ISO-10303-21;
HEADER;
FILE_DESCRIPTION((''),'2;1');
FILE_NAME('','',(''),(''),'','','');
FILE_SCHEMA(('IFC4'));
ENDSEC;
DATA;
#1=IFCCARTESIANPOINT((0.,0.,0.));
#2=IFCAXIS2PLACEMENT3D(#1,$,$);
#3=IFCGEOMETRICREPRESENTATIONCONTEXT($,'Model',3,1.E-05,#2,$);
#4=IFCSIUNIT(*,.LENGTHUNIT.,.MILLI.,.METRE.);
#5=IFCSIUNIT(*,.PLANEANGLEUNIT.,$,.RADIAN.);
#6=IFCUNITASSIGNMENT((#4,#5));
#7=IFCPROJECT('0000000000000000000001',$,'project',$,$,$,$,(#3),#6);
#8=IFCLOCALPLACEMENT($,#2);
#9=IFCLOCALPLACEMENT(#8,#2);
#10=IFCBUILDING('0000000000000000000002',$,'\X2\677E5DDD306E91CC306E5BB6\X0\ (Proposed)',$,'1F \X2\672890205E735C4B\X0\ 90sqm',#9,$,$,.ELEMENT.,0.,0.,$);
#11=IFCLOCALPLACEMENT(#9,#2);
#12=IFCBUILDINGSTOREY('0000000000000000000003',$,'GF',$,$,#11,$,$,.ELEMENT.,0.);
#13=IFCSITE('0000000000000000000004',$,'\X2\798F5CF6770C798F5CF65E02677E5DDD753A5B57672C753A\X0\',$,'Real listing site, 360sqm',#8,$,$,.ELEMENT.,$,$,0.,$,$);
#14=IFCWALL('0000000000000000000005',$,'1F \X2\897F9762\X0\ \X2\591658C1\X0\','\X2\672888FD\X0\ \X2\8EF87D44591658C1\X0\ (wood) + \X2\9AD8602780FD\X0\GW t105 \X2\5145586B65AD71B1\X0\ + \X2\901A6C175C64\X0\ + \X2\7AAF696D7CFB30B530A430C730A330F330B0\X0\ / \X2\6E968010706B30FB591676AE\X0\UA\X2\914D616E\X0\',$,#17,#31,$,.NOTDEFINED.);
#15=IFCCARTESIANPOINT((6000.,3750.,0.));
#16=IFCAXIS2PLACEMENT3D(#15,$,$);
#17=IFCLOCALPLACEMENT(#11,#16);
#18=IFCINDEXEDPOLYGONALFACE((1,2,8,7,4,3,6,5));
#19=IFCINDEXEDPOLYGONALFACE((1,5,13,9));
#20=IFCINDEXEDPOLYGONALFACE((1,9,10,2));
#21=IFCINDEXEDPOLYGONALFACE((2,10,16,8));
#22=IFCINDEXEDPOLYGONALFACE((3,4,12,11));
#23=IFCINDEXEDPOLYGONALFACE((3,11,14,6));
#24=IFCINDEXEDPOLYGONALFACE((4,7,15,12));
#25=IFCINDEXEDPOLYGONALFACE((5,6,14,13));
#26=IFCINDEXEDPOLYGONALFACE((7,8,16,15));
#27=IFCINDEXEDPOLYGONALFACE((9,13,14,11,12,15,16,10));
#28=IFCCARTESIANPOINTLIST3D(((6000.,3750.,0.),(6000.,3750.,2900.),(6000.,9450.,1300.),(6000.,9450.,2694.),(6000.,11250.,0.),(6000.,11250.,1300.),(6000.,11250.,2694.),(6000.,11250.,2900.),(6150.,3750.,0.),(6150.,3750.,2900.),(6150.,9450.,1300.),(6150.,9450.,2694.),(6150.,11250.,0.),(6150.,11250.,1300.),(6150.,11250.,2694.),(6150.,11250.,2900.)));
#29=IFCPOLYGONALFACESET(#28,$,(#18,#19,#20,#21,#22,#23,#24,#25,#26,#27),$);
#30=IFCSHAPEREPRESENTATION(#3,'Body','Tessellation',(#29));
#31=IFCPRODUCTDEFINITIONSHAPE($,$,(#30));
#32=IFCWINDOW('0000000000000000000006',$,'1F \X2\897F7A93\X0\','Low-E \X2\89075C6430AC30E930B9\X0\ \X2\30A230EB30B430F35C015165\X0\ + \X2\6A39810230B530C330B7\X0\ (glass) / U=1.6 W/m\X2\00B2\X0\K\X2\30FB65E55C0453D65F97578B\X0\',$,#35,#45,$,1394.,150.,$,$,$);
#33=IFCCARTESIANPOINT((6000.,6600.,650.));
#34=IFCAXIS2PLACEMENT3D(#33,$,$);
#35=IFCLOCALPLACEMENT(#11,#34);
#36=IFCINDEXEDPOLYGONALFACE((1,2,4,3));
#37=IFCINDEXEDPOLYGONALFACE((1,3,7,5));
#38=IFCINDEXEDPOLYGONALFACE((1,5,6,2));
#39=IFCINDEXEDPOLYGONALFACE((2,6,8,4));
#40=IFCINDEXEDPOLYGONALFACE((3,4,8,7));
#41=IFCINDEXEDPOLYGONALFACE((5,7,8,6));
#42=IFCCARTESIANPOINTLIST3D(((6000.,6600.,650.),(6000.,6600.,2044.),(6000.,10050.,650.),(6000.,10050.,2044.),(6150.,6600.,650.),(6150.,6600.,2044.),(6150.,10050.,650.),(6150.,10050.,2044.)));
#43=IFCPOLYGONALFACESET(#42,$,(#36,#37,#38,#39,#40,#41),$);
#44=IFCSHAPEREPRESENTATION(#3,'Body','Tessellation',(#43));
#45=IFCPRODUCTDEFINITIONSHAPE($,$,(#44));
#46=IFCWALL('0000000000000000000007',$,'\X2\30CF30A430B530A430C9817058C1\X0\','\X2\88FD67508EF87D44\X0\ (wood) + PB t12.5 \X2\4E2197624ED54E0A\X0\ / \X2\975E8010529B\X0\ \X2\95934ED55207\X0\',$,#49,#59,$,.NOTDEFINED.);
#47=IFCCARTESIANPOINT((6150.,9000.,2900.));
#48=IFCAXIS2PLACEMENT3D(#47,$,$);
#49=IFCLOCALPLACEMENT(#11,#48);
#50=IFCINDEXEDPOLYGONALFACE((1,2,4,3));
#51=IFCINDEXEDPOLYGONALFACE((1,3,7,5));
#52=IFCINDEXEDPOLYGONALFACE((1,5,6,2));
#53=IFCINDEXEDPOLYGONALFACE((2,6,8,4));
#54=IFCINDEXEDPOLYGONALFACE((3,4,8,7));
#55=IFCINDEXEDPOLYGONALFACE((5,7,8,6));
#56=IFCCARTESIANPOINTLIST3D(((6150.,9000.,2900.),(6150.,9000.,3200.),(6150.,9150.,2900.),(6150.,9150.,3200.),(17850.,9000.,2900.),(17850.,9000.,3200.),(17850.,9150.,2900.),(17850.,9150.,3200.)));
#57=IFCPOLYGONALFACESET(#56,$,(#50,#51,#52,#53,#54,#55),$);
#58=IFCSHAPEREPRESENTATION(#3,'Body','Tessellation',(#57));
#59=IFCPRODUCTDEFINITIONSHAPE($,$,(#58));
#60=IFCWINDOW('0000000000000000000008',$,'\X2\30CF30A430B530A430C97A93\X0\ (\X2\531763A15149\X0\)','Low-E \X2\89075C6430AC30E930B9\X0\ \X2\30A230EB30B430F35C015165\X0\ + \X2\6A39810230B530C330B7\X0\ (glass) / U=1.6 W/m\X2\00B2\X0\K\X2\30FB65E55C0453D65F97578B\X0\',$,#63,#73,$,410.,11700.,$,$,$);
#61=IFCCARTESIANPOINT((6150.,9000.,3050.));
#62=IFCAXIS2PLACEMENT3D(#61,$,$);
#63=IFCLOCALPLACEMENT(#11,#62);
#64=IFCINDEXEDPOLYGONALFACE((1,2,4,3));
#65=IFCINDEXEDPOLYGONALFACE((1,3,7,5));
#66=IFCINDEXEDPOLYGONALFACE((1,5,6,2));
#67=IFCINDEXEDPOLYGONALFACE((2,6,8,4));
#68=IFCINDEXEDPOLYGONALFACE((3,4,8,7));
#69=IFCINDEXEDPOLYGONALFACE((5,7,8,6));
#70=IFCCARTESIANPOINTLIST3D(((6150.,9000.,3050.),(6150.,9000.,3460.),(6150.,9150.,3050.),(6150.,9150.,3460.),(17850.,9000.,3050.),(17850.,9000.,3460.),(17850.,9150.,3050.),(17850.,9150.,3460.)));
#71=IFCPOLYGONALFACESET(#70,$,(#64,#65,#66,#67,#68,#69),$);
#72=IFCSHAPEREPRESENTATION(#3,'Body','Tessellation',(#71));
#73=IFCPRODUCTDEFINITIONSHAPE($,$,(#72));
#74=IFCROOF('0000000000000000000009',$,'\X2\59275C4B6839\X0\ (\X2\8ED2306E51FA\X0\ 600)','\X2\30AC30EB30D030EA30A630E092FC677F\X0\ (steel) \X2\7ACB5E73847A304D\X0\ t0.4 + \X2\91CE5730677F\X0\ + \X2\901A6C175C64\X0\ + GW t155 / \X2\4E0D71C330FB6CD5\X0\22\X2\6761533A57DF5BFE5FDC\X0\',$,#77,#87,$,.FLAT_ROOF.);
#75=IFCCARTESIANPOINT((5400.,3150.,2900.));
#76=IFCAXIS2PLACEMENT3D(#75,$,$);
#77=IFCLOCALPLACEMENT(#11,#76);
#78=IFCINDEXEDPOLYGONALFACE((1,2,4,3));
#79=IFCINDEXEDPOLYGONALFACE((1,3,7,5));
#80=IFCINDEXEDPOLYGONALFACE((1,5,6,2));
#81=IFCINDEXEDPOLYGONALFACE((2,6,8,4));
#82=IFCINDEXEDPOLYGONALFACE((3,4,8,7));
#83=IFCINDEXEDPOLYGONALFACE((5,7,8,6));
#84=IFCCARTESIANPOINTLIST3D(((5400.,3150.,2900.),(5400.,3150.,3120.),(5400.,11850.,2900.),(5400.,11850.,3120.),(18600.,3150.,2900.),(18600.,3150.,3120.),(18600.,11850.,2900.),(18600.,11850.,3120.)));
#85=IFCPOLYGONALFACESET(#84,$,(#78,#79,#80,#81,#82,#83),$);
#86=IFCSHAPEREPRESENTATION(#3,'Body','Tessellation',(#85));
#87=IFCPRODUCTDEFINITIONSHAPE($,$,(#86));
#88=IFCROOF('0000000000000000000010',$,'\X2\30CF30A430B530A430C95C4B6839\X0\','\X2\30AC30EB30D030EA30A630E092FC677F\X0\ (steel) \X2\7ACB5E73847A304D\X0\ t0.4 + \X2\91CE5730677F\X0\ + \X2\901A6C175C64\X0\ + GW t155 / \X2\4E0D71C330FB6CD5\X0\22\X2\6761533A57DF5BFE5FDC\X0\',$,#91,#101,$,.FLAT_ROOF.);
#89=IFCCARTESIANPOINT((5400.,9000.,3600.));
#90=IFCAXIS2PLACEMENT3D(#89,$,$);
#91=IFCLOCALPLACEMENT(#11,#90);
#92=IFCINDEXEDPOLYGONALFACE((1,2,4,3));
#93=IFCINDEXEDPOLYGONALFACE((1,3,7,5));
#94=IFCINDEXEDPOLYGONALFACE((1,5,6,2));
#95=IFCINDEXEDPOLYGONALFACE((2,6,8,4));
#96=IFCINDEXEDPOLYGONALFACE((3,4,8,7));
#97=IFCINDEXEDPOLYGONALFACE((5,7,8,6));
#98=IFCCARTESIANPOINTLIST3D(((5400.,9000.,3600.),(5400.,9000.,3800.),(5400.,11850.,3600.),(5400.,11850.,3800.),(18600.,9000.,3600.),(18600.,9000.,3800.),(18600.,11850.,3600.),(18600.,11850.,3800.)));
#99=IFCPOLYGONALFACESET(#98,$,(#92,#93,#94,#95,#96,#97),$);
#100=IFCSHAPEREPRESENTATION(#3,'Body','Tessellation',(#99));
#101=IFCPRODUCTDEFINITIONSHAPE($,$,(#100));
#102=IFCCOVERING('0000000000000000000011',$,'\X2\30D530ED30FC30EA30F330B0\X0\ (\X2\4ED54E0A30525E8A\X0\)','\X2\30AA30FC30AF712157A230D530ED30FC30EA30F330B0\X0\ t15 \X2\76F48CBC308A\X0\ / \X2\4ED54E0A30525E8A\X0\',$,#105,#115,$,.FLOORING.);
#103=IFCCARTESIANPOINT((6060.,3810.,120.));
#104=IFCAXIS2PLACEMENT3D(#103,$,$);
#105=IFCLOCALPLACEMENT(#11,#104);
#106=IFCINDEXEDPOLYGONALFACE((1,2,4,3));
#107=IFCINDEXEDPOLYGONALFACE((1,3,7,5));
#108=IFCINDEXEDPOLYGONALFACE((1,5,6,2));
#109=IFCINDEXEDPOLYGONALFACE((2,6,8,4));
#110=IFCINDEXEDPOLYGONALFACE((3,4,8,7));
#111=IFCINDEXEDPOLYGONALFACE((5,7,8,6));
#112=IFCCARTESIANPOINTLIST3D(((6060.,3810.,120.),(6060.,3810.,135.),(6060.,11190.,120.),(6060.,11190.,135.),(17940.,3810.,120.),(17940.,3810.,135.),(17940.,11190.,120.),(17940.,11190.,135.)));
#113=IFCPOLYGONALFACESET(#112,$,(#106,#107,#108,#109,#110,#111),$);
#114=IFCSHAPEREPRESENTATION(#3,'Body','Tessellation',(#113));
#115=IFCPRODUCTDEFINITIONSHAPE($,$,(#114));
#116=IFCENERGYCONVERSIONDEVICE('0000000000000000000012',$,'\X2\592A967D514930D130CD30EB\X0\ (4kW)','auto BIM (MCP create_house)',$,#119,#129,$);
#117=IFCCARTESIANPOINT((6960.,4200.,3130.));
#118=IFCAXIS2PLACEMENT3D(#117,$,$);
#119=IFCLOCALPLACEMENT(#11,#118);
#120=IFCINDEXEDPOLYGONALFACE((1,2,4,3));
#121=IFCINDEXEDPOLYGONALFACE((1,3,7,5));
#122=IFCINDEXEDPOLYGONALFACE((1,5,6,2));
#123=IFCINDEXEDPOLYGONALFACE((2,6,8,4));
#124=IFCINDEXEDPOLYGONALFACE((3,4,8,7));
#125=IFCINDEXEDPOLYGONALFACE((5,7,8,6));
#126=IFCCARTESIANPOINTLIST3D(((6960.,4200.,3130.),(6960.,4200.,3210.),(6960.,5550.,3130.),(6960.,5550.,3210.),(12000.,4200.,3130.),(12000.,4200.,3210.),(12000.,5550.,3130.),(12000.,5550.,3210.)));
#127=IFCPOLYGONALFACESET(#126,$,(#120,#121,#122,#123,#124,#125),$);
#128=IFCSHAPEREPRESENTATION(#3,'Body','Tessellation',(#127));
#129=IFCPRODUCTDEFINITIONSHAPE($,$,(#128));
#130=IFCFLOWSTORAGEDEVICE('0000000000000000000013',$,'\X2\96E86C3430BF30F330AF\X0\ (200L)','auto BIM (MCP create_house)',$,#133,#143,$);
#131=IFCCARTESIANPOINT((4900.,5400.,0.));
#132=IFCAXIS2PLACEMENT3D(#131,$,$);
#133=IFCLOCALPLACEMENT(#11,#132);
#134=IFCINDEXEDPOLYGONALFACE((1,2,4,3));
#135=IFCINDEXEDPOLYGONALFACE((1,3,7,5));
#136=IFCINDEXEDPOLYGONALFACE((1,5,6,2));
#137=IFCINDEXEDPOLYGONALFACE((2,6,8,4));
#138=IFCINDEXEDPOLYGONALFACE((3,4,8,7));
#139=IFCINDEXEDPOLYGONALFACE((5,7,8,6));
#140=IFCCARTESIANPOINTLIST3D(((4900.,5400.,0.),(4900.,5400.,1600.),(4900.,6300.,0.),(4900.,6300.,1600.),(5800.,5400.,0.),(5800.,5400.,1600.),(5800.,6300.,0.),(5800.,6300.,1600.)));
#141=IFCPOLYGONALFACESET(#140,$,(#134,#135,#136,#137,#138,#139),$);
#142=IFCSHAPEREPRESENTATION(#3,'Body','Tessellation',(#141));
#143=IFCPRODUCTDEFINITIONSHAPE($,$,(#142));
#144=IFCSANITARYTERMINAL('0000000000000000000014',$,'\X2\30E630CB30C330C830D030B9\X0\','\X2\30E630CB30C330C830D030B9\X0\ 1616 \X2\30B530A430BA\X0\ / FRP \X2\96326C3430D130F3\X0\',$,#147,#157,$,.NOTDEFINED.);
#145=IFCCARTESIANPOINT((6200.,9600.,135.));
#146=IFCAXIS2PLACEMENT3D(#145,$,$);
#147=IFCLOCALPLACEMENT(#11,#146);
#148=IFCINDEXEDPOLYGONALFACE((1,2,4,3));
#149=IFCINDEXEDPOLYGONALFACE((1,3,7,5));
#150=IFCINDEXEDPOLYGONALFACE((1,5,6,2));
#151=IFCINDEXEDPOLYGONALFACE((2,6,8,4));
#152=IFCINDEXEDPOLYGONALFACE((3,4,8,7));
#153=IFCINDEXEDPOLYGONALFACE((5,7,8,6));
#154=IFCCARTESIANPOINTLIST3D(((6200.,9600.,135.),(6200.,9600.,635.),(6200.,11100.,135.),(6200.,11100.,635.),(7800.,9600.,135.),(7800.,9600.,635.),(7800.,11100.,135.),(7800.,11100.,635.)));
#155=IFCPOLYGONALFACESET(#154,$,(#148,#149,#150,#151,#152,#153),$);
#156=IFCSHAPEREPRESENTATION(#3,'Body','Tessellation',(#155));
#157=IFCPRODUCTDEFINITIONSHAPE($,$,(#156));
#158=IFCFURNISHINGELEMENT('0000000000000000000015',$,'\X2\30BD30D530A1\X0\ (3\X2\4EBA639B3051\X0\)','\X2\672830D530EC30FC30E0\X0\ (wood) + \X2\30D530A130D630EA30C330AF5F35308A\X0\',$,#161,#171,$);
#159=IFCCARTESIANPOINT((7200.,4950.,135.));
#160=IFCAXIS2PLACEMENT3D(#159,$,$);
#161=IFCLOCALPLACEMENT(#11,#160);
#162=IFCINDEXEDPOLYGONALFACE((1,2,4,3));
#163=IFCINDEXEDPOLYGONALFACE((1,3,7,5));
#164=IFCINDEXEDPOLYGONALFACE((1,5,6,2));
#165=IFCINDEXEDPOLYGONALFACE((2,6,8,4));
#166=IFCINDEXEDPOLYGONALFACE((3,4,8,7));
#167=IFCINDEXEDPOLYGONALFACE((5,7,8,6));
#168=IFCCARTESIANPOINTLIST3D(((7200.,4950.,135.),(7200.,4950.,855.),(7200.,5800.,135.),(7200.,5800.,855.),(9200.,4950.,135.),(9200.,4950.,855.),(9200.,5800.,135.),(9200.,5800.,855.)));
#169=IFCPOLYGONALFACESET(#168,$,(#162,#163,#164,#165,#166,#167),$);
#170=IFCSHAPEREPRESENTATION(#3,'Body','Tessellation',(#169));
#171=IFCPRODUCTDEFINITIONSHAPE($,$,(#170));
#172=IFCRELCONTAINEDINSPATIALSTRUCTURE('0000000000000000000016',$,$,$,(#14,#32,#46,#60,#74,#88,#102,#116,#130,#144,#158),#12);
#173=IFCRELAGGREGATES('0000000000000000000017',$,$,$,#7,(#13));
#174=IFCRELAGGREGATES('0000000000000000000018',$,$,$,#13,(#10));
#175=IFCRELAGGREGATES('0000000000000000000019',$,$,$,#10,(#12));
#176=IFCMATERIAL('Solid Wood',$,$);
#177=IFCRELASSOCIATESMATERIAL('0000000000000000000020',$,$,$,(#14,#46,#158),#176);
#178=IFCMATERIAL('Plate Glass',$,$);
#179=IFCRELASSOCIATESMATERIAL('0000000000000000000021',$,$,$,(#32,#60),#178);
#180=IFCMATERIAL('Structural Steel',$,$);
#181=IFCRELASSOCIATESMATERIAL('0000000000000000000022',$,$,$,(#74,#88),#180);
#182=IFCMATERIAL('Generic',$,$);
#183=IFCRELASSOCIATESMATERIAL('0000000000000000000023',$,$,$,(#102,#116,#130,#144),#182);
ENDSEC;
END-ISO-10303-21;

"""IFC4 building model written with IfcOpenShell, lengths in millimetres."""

from ifc_helpers import new_model, si_unit, frame, frame_2d, origin, place, context, project, spatial, rectangle, extrude, material, element, fill, save


model = new_model("IFC4")

# Units and contexts
model_context = context("Model", 3, precision=1e-05, world=origin())
ifc_project = project(units=[si_unit("LENGTHUNIT", "METRE", prefix="MILLI"), si_unit("PLANEANGLEUNIT", "RADIAN")], contexts=[model_context])

# Site, building, storey
site_placement = place(None, origin())
site = spatial("IfcSite", under=ifc_project, at=site_placement, Name="福島県福島市松川町字本町", ObjectType="Real listing site, 360sqm", CompositionType="ELEMENT", RefElevation=0.0)
building_placement = place(site_placement, origin())
building = spatial("IfcBuilding", under=site, at=building_placement, Name="松川の里の家 (Proposed)", ObjectType="1F 木造平屋 90sqm", CompositionType="ELEMENT", ElevationOfRefHeight=0.0, ElevationOfTerrain=0.0)
storey_placement = place(building_placement, origin())
storey = spatial("IfcBuildingStorey", under=building, at=storey_placement, Name="GF", CompositionType="ELEMENT", Elevation=0.0)

# Shared definitions
ifc_material_1 = material(Name="Solid Wood")

# Shared definitions
ifc_material_2 = material(Name="Plate Glass")

# Wall, opening, window
wall_1_placement = place(storey_placement, frame((6000.0, 3750.0, 0.0)))
wall_1 = element("IfcWall", 1, at=wall_1_placement, inside=storey, material=ifc_material_1, Name="1F 西面 外壁", Description="木製 軸組外壁 (wood) + 高性能GW t105 充填断熱 + 通気層 + 窯業系サイディング / 準耐火・外皮UA配慮", PredefinedType="NOTDEFINED", context=model_context, shape_type="SweptSolid", body=[
    extrude(rectangle(XDim=150.0, YDim=7500.0, at=frame_2d((75.0, 3750.0))), frame((6000.0, 3750.0, 0.0)), (0.0, 0.0, 1.0), 2900.0),
])
opening_1_placement = place(storey_placement, frame((6000.0, 6600.0, 650.0)))
opening_1 = element("IfcOpeningElement", 2, at=opening_1_placement, cuts=wall_1, PredefinedType="NOTDEFINED", context=model_context, shape_type="SweptSolid", body=[
    extrude(rectangle(XDim=150.0, YDim=3450.0, at=frame_2d((75.0, 1725.0))), frame((6000.0, 6600.0, 650.0)), (0.0, 0.0, 1.0), 1394.0),
])
window_1_placement = place(storey_placement, frame((6000.0, 6600.0, 650.0)))
window_1 = element("IfcWindow", 3, at=window_1_placement, inside=storey, material=ifc_material_2, Name="1F 西窓", Description="Low-E 複層ガラス アルゴン封入 + 樹脂サッシ (glass) / U=1.6 W/m²K・日射取得型", OverallHeight=1394.0, OverallWidth=150.0, context=model_context, shape_type="SweptSolid", body=[
    extrude(rectangle(XDim=150.0, YDim=3450.0, at=frame_2d((75.0, 1725.0))), frame((6000.0, 6600.0, 650.0)), (0.0, 0.0, 1.0), 1394.0),
])
fill(opening_1, window_1)

# Wall, opening, window
wall_2_placement = place(storey_placement, frame((6150.0, 9000.0, 2900.0)))
wall_2 = element("IfcWall", 4, at=wall_2_placement, inside=storey, material=ifc_material_1, Name="ハイサイド腰壁", Description="製材軸組 (wood) + PB t12.5 両面仕上 / 非耐力 間仕切", PredefinedType="NOTDEFINED", context=model_context, shape_type="SweptSolid", body=[
    extrude(rectangle(XDim=11700.0, YDim=150.0, at=frame_2d((5850.0, 75.0))), frame((6150.0, 9000.0, 2900.0)), (0.0, 0.0, 1.0), 700.0),
])
opening_2_placement = place(storey_placement, frame((6150.0, 9000.0, 3050.0)))
opening_2 = element("IfcOpeningElement", 5, at=opening_2_placement, cuts=wall_2, PredefinedType="NOTDEFINED", context=model_context, shape_type="SweptSolid", body=[
    extrude(rectangle(XDim=11700.0, YDim=150.0, at=frame_2d((5850.0, 75.0))), frame((6150.0, 9000.0, 3050.0)), (0.0, 0.0, 1.0), 410.0),
])
window_2_placement = place(storey_placement, frame((6150.0, 9000.0, 3050.0)))
window_2 = element("IfcWindow", 6, at=window_2_placement, inside=storey, material=ifc_material_2, Name="ハイサイド窓 (北採光)", Description="Low-E 複層ガラス アルゴン封入 + 樹脂サッシ (glass) / U=1.6 W/m²K・日射取得型", OverallHeight=410.0, OverallWidth=11700.0, context=model_context, shape_type="SweptSolid", body=[
    extrude(rectangle(XDim=11700.0, YDim=150.0, at=frame_2d((5850.0, 75.0))), frame((6150.0, 9000.0, 3050.0)), (0.0, 0.0, 1.0), 410.0),
])
fill(opening_2, window_2)

# Roofs
ifc_material_3 = material(Name="Structural Steel")
roof_1_placement = place(storey_placement, frame((5400.0, 3150.0, 2900.0)))
element("IfcRoof", 7, at=roof_1_placement, inside=storey, material=ifc_material_3, Name="大屋根 (軒の出 600)", Description="ガルバリウム鋼板 (steel) 立平葺き t0.4 + 野地板 + 通気層 + GW t155 / 不燃・法22条区域対応", PredefinedType="FLAT_ROOF", context=model_context, shape_type="SweptSolid", body=[
    extrude(rectangle(XDim=13200.0, YDim=8700.0, at=frame_2d((6600.0, 4350.0))), frame((5400.0, 3150.0, 2900.0)), (0.0, 0.0, 1.0), 220.0),
])
roof_2_placement = place(storey_placement, frame((5400.0, 9000.0, 3600.0)))
element("IfcRoof", 8, at=roof_2_placement, inside=storey, material=ifc_material_3, Name="ハイサイド屋根", Description="ガルバリウム鋼板 (steel) 立平葺き t0.4 + 野地板 + 通気層 + GW t155 / 不燃・法22条区域対応", PredefinedType="FLAT_ROOF", context=model_context, shape_type="SweptSolid", body=[
    extrude(rectangle(XDim=13200.0, YDim=2850.0, at=frame_2d((6600.0, 1425.0))), frame((5400.0, 9000.0, 3600.0)), (0.0, 0.0, 1.0), 200.0),
])

# Covering
ifc_material_4 = material(Name="Generic")
covering_placement = place(storey_placement, frame((6060.0, 3810.0, 120.0)))
element("IfcCovering", 9, at=covering_placement, inside=storey, material=ifc_material_4, Name="フローリング (仕上げ床)", Description="オーク無垢フローリング t15 直貼り / 仕上げ床", PredefinedType="FLOORING", context=model_context, shape_type="SweptSolid", body=[
    extrude(rectangle(XDim=11880.0, YDim=7380.0, at=frame_2d((5940.0, 3690.0))), frame((6060.0, 3810.0, 120.0)), (0.0, 0.0, 1.0), 15.0),
])

# Energy conversion device
energy_conversion_device_placement = place(storey_placement, frame((6960.0, 4200.0, 3130.0)))
element("IfcEnergyConversionDevice", 10, at=energy_conversion_device_placement, inside=storey, material=ifc_material_4, Name="太陽光パネル (4kW)", Description="auto BIM (MCP create_house)", context=model_context, shape_type="SweptSolid", body=[
    extrude(rectangle(XDim=5040.0, YDim=1350.0, at=frame_2d((2520.0, 675.0))), frame((6960.0, 4200.0, 3130.0)), (0.0, 0.0, 1.0), 80.0),
])

# Flow storage device
flow_storage_device_placement = place(storey_placement, frame((4900.0, 5400.0, 0.0)))
element("IfcFlowStorageDevice", 11, at=flow_storage_device_placement, inside=storey, material=ifc_material_4, Name="雨水タンク (200L)", Description="auto BIM (MCP create_house)", context=model_context, shape_type="SweptSolid", body=[
    extrude(rectangle(XDim=900.0, YDim=900.0, at=frame_2d((450.0, 450.0))), frame((4900.0, 5400.0, 0.0)), (0.0, 0.0, 1.0), 1600.0),
])

# Sanitary terminal
sanitary_terminal_placement = place(storey_placement, frame((6200.0, 9600.0, 135.0)))
element("IfcSanitaryTerminal", 12, at=sanitary_terminal_placement, inside=storey, material=ifc_material_4, Name="ユニットバス", Description="ユニットバス 1616 サイズ / FRP 防水パン", PredefinedType="NOTDEFINED", context=model_context, shape_type="SweptSolid", body=[
    extrude(rectangle(XDim=1600.0, YDim=1500.0, at=frame_2d((800.0, 750.0))), frame((6200.0, 9600.0, 135.0)), (0.0, 0.0, 1.0), 500.0),
])

# Furnishing element
furnishing_placement = place(storey_placement, frame((7200.0, 4950.0, 135.0)))
element("IfcFurnishingElement", 13, at=furnishing_placement, inside=storey, material=ifc_material_1, Name="ソファ (3人掛け)", Description="木フレーム (wood) + ファブリック張り", context=model_context, shape_type="SweptSolid", body=[
    extrude(rectangle(XDim=2000.0, YDim=850.0, at=frame_2d((1000.0, 425.0))), frame((7200.0, 4950.0, 135.0)), (0.0, 0.0, 1.0), 720.0),
])

save(model, "model.ifc")
